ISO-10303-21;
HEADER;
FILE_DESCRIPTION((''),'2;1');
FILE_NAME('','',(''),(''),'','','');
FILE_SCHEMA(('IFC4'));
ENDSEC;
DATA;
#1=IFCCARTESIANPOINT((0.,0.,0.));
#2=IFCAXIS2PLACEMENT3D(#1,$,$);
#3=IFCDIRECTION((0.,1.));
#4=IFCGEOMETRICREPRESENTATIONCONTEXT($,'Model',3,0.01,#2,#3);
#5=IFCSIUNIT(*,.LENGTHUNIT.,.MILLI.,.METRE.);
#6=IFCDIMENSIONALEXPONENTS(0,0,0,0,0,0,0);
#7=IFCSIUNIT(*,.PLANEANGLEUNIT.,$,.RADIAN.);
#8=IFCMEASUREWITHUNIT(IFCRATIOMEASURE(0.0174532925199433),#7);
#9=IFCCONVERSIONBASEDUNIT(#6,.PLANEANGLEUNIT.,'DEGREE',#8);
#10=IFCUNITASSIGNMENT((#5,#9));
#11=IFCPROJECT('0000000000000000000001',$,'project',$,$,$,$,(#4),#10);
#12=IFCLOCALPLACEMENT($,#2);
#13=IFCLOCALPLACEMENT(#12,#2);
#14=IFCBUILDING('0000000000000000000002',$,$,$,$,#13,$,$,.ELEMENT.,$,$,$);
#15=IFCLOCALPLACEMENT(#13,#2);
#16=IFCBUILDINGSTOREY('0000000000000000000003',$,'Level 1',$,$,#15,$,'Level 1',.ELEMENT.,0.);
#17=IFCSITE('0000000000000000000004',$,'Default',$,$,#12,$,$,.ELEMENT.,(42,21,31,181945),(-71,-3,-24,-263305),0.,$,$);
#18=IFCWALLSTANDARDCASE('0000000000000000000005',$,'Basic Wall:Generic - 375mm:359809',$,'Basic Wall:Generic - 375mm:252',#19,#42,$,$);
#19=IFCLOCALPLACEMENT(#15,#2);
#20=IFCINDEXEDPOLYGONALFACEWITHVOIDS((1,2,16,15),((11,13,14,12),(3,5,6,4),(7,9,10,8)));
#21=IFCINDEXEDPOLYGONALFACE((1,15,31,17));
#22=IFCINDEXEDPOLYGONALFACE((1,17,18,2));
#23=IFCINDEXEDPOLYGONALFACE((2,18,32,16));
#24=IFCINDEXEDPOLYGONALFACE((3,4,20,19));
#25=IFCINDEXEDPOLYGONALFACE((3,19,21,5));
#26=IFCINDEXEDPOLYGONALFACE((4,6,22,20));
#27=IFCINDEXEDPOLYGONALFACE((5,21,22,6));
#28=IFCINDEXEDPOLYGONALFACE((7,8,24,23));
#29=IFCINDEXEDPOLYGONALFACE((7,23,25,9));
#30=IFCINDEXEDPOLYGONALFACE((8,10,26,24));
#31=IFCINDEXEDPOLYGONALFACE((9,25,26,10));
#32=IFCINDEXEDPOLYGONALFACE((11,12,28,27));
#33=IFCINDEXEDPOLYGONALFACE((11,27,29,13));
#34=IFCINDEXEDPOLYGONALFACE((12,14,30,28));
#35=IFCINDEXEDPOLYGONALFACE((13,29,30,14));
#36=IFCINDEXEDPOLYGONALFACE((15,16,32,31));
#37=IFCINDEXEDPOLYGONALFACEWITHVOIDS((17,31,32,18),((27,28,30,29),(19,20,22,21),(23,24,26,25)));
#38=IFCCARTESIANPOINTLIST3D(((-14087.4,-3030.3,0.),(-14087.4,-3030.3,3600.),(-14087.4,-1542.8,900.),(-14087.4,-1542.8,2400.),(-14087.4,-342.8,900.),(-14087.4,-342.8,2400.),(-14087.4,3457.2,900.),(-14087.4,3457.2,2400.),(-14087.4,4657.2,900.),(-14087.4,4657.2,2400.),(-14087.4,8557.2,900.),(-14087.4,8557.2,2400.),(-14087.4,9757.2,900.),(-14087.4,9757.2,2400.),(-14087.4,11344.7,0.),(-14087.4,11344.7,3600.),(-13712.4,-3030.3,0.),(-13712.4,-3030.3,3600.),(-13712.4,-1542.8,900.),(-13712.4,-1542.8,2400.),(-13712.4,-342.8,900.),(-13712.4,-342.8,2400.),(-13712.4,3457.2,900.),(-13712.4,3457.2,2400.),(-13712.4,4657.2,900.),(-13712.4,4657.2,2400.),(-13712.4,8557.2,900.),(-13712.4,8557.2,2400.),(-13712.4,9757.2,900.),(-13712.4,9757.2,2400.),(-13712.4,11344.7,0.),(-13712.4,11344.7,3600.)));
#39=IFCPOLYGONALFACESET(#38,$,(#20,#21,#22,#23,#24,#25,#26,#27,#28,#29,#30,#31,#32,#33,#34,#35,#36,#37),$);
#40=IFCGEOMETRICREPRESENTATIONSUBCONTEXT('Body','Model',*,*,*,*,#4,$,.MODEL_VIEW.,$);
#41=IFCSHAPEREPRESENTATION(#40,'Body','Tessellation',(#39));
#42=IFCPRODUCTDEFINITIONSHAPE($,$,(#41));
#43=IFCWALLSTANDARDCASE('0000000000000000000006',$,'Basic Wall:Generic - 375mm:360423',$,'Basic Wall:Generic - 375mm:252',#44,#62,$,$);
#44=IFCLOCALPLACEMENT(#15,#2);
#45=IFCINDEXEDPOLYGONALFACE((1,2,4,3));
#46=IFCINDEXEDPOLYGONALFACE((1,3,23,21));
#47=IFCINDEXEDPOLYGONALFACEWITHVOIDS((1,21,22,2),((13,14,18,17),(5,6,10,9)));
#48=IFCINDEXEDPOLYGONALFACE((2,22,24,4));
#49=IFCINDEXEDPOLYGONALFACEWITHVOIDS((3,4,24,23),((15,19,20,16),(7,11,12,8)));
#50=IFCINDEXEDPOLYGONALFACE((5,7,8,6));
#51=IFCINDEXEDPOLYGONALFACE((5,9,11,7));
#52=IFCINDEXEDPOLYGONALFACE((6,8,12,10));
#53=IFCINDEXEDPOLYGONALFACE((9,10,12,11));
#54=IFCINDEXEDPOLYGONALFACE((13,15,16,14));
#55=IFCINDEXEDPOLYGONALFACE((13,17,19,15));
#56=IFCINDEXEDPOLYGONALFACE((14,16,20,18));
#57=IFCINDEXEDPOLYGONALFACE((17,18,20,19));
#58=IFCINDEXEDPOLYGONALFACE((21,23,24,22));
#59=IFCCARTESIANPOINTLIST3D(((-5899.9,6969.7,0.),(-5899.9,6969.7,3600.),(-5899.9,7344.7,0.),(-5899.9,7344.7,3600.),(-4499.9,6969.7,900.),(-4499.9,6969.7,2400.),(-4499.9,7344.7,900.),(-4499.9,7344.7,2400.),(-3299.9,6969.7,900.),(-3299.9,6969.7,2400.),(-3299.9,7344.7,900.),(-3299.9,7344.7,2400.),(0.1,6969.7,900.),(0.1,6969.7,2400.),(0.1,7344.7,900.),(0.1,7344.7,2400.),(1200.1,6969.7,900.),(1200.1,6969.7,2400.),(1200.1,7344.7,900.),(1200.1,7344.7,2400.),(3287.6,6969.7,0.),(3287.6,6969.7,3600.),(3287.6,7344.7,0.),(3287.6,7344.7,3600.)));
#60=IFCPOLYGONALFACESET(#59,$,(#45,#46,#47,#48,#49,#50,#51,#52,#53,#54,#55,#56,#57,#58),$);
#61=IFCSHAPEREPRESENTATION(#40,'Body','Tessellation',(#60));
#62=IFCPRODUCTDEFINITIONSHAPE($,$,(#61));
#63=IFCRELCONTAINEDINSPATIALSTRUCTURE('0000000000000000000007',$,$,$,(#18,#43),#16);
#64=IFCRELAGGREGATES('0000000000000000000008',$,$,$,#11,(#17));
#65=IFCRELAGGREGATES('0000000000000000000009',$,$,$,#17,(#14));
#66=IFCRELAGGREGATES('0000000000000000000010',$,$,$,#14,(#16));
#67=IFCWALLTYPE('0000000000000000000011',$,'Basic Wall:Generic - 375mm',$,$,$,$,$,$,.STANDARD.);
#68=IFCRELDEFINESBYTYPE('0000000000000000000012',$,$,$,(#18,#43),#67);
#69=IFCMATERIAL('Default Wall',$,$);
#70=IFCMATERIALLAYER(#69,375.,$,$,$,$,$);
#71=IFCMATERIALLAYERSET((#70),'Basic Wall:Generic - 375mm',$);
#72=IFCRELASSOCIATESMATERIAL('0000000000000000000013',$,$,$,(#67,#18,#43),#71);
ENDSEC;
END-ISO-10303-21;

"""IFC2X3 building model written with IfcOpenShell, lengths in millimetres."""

from ifc_helpers import new_model, entity, si_unit, converted_unit, direction, frame, frame_2d, origin, place, context, subcontext, project, spatial, polyline, rectangle, extrude, clip, bounded_halfspace, material, layer, layer_set, layer_usage, type_object, element, save


model = new_model("IFC2X3")

# Units and contexts
model_context = context("Model", 3, precision=0.01, world=origin(), true_north=direction((0.0, 1.0)))
body_context = subcontext(model_context, "Body", "Model", "MODEL_VIEW")
ifc_project = project(units=[si_unit("LENGTHUNIT", "METRE", prefix="MILLI"), converted_unit("PLANEANGLEUNIT", "DEGREE", entity("IfcRatioMeasure", 0.0174532925199433), si_unit("PLANEANGLEUNIT", "RADIAN"), dimensions=[0, 0, 0, 0, 0, 0, 0])], contexts=[model_context])

# Site, building, storey
site_placement = place(None, origin())
site = spatial("IfcSite", under=ifc_project, at=site_placement, Name="Default", CompositionType="ELEMENT", RefLatitude=(42, 21, 31, 181945), RefLongitude=(-71, -3, -24, -263305), RefElevation=0.0)
building_placement = place(site_placement, origin())
building = spatial("IfcBuilding", under=site, at=building_placement, CompositionType="ELEMENT")
storey_placement = place(building_placement, origin())
storey = spatial("IfcBuildingStorey", under=building, at=storey_placement, Name="Level 1", LongName="Level 1", CompositionType="ELEMENT", Elevation=0.0)

# Walls, openings
ifc_material_1 = material(Name="Default Wall")
ifc_layer_1 = layer(ifc_material_1, 375.0)
ifc_layer_set_1 = layer_set([ifc_layer_1], Name="Basic Wall:Generic - 375mm")
ifc_layer_usage_1 = layer_usage(ifc_layer_set_1, "AXIS2", "NEGATIVE", 187.5)
wall_type_1 = type_object("IfcWallType", Name="Basic Wall:Generic - 375mm", PredefinedType="STANDARD", material=ifc_layer_set_1)
wall_1_placement = place(storey_placement, frame((-13899.9, 11344.7, 0.0), z_axis=(0.0, 0.0, 1.0), x_axis=(0.0, -1.0, 0.0)))
wall_1 = element("IfcWallStandardCase", 1, at=wall_1_placement, inside=storey, type_object=wall_type_1, material=ifc_layer_usage_1, Name="Basic Wall:Generic - 375mm:359809", ObjectType="Basic Wall:Generic - 375mm:252", context=body_context, shape_type="Clipping", body=[
    clip(extrude(rectangle(XDim=14375.0, YDim=375.0, at=frame_2d((7187.5, 0.0), x_axis=(-1.0, 0.0))), origin(), (0.0, 0.0, 1.0), 3600.0), bounded_halfspace(frame((0.0, -187.5, 3600.0), z_axis=(0.0, 0.0, -1.0), x_axis=(0.0, 1.0, 0.0)), True, frame((0.0, -187.5, 3600.0)), polyline([(0.0, 0.0), (14375.0, 0.0), (14375.0, 375.0), (14000.0, 375.0), (10487.5, 375.0), (10287.5, 375.0), (4287.5, 375.0), (4087.5, 375.0), (375.0, 375.0), (0.0, 375.0), (0.0, 0.0)]))),
])
opening_1_placement = place(wall_1_placement, frame((1587.5, -187.5, 900.0)))
element("IfcOpeningElement", 2, at=opening_1_placement, cuts=wall_1, ObjectType="Opening", context=body_context, shape_type="SweptSolid", body=[
    extrude(rectangle(XDim=1500.0, YDim=1200.0, at=frame_2d((750.0, 600.0), x_axis=(-1.0, 0.0))), frame((0.0, 0.0, 0.0), z_axis=(0.0, 1.0, 0.0), x_axis=(0.0, 0.0, 1.0)), (0.0, 0.0, 1.0), 375.0),
])
opening_2_placement = place(wall_1_placement, frame((6687.5, -187.5, 900.0)))
element("IfcOpeningElement", 3, at=opening_2_placement, cuts=wall_1, ObjectType="Opening", context=body_context, shape_type="SweptSolid", body=[
    extrude(rectangle(XDim=1500.0, YDim=1200.0, at=frame_2d((750.0, 600.0), x_axis=(-1.0, 0.0))), frame((0.0, 0.0, 0.0), z_axis=(0.0, 1.0, 0.0), x_axis=(0.0, 0.0, 1.0)), (0.0, 0.0, 1.0), 375.0),
])
opening_3_placement = place(wall_1_placement, frame((11687.5, -187.5, 900.0)))
element("IfcOpeningElement", 4, at=opening_3_placement, cuts=wall_1, ObjectType="Opening", context=body_context, shape_type="SweptSolid", body=[
    extrude(rectangle(XDim=1500.0, YDim=1200.0, at=frame_2d((750.0, 600.0), x_axis=(-1.0, 0.0))), frame((0.0, 0.0, 0.0), z_axis=(0.0, 1.0, 0.0), x_axis=(0.0, 0.0, 1.0)), (0.0, 0.0, 1.0), 375.0),
])
ifc_layer_usage_2 = layer_usage(ifc_layer_set_1, "AXIS2", "NEGATIVE", 187.5)
wall_2_placement = place(storey_placement, frame((-5899.9, 7157.2, 0.0)))
wall_2 = element("IfcWallStandardCase", 5, at=wall_2_placement, inside=storey, type_object=wall_type_1, material=ifc_layer_usage_2, Name="Basic Wall:Generic - 375mm:360423", ObjectType="Basic Wall:Generic - 375mm:252", context=body_context, shape_type="Clipping", body=[
    clip(extrude(rectangle(XDim=9187.5, YDim=375.0, at=frame_2d((4593.8, 0.0), x_axis=(-1.0, 0.0))), origin(), (0.0, 0.0, 1.0), 3600.0), bounded_halfspace(frame((0.0, -187.5, 3600.0), z_axis=(0.0, 0.0, -1.0), x_axis=(1.0, 0.0, 0.0)), True, frame((0.0, -187.5, 3600.0)), polyline([(0.0, 0.0), (187.5, 0.0), (9187.5, 0.0), (9187.5, 375.0), (8812.5, 375.0), (4100.0, 375.0), (3900.0, 375.0), (0.0, 375.0), (0.0, 287.5), (0.0, 87.5), (0.0, 0.0)]))),
])
opening_4_placement = place(wall_2_placement, frame((1400.0, -187.5, 900.0)))
element("IfcOpeningElement", 6, at=opening_4_placement, cuts=wall_2, ObjectType="Opening", context=body_context, shape_type="SweptSolid", body=[
    extrude(rectangle(XDim=1500.0, YDim=1200.0, at=frame_2d((750.0, 600.0), x_axis=(-1.0, 0.0))), frame((0.0, 0.0, 0.0), z_axis=(0.0, 1.0, 0.0), x_axis=(0.0, 0.0, 1.0)), (0.0, 0.0, 1.0), 375.0),
])
opening_5_placement = place(wall_2_placement, frame((5900.0, -187.5, 900.0)))
element("IfcOpeningElement", 7, at=opening_5_placement, cuts=wall_2, ObjectType="Opening", context=body_context, shape_type="SweptSolid", body=[
    extrude(rectangle(XDim=1500.0, YDim=1200.0, at=frame_2d((750.0, 600.0), x_axis=(-1.0, 0.0))), frame((0.0, 0.0, 0.0), z_axis=(0.0, 1.0, 0.0), x_axis=(0.0, 0.0, 1.0)), (0.0, 0.0, 1.0), 375.0),
])

save(model, "model.ifc")
